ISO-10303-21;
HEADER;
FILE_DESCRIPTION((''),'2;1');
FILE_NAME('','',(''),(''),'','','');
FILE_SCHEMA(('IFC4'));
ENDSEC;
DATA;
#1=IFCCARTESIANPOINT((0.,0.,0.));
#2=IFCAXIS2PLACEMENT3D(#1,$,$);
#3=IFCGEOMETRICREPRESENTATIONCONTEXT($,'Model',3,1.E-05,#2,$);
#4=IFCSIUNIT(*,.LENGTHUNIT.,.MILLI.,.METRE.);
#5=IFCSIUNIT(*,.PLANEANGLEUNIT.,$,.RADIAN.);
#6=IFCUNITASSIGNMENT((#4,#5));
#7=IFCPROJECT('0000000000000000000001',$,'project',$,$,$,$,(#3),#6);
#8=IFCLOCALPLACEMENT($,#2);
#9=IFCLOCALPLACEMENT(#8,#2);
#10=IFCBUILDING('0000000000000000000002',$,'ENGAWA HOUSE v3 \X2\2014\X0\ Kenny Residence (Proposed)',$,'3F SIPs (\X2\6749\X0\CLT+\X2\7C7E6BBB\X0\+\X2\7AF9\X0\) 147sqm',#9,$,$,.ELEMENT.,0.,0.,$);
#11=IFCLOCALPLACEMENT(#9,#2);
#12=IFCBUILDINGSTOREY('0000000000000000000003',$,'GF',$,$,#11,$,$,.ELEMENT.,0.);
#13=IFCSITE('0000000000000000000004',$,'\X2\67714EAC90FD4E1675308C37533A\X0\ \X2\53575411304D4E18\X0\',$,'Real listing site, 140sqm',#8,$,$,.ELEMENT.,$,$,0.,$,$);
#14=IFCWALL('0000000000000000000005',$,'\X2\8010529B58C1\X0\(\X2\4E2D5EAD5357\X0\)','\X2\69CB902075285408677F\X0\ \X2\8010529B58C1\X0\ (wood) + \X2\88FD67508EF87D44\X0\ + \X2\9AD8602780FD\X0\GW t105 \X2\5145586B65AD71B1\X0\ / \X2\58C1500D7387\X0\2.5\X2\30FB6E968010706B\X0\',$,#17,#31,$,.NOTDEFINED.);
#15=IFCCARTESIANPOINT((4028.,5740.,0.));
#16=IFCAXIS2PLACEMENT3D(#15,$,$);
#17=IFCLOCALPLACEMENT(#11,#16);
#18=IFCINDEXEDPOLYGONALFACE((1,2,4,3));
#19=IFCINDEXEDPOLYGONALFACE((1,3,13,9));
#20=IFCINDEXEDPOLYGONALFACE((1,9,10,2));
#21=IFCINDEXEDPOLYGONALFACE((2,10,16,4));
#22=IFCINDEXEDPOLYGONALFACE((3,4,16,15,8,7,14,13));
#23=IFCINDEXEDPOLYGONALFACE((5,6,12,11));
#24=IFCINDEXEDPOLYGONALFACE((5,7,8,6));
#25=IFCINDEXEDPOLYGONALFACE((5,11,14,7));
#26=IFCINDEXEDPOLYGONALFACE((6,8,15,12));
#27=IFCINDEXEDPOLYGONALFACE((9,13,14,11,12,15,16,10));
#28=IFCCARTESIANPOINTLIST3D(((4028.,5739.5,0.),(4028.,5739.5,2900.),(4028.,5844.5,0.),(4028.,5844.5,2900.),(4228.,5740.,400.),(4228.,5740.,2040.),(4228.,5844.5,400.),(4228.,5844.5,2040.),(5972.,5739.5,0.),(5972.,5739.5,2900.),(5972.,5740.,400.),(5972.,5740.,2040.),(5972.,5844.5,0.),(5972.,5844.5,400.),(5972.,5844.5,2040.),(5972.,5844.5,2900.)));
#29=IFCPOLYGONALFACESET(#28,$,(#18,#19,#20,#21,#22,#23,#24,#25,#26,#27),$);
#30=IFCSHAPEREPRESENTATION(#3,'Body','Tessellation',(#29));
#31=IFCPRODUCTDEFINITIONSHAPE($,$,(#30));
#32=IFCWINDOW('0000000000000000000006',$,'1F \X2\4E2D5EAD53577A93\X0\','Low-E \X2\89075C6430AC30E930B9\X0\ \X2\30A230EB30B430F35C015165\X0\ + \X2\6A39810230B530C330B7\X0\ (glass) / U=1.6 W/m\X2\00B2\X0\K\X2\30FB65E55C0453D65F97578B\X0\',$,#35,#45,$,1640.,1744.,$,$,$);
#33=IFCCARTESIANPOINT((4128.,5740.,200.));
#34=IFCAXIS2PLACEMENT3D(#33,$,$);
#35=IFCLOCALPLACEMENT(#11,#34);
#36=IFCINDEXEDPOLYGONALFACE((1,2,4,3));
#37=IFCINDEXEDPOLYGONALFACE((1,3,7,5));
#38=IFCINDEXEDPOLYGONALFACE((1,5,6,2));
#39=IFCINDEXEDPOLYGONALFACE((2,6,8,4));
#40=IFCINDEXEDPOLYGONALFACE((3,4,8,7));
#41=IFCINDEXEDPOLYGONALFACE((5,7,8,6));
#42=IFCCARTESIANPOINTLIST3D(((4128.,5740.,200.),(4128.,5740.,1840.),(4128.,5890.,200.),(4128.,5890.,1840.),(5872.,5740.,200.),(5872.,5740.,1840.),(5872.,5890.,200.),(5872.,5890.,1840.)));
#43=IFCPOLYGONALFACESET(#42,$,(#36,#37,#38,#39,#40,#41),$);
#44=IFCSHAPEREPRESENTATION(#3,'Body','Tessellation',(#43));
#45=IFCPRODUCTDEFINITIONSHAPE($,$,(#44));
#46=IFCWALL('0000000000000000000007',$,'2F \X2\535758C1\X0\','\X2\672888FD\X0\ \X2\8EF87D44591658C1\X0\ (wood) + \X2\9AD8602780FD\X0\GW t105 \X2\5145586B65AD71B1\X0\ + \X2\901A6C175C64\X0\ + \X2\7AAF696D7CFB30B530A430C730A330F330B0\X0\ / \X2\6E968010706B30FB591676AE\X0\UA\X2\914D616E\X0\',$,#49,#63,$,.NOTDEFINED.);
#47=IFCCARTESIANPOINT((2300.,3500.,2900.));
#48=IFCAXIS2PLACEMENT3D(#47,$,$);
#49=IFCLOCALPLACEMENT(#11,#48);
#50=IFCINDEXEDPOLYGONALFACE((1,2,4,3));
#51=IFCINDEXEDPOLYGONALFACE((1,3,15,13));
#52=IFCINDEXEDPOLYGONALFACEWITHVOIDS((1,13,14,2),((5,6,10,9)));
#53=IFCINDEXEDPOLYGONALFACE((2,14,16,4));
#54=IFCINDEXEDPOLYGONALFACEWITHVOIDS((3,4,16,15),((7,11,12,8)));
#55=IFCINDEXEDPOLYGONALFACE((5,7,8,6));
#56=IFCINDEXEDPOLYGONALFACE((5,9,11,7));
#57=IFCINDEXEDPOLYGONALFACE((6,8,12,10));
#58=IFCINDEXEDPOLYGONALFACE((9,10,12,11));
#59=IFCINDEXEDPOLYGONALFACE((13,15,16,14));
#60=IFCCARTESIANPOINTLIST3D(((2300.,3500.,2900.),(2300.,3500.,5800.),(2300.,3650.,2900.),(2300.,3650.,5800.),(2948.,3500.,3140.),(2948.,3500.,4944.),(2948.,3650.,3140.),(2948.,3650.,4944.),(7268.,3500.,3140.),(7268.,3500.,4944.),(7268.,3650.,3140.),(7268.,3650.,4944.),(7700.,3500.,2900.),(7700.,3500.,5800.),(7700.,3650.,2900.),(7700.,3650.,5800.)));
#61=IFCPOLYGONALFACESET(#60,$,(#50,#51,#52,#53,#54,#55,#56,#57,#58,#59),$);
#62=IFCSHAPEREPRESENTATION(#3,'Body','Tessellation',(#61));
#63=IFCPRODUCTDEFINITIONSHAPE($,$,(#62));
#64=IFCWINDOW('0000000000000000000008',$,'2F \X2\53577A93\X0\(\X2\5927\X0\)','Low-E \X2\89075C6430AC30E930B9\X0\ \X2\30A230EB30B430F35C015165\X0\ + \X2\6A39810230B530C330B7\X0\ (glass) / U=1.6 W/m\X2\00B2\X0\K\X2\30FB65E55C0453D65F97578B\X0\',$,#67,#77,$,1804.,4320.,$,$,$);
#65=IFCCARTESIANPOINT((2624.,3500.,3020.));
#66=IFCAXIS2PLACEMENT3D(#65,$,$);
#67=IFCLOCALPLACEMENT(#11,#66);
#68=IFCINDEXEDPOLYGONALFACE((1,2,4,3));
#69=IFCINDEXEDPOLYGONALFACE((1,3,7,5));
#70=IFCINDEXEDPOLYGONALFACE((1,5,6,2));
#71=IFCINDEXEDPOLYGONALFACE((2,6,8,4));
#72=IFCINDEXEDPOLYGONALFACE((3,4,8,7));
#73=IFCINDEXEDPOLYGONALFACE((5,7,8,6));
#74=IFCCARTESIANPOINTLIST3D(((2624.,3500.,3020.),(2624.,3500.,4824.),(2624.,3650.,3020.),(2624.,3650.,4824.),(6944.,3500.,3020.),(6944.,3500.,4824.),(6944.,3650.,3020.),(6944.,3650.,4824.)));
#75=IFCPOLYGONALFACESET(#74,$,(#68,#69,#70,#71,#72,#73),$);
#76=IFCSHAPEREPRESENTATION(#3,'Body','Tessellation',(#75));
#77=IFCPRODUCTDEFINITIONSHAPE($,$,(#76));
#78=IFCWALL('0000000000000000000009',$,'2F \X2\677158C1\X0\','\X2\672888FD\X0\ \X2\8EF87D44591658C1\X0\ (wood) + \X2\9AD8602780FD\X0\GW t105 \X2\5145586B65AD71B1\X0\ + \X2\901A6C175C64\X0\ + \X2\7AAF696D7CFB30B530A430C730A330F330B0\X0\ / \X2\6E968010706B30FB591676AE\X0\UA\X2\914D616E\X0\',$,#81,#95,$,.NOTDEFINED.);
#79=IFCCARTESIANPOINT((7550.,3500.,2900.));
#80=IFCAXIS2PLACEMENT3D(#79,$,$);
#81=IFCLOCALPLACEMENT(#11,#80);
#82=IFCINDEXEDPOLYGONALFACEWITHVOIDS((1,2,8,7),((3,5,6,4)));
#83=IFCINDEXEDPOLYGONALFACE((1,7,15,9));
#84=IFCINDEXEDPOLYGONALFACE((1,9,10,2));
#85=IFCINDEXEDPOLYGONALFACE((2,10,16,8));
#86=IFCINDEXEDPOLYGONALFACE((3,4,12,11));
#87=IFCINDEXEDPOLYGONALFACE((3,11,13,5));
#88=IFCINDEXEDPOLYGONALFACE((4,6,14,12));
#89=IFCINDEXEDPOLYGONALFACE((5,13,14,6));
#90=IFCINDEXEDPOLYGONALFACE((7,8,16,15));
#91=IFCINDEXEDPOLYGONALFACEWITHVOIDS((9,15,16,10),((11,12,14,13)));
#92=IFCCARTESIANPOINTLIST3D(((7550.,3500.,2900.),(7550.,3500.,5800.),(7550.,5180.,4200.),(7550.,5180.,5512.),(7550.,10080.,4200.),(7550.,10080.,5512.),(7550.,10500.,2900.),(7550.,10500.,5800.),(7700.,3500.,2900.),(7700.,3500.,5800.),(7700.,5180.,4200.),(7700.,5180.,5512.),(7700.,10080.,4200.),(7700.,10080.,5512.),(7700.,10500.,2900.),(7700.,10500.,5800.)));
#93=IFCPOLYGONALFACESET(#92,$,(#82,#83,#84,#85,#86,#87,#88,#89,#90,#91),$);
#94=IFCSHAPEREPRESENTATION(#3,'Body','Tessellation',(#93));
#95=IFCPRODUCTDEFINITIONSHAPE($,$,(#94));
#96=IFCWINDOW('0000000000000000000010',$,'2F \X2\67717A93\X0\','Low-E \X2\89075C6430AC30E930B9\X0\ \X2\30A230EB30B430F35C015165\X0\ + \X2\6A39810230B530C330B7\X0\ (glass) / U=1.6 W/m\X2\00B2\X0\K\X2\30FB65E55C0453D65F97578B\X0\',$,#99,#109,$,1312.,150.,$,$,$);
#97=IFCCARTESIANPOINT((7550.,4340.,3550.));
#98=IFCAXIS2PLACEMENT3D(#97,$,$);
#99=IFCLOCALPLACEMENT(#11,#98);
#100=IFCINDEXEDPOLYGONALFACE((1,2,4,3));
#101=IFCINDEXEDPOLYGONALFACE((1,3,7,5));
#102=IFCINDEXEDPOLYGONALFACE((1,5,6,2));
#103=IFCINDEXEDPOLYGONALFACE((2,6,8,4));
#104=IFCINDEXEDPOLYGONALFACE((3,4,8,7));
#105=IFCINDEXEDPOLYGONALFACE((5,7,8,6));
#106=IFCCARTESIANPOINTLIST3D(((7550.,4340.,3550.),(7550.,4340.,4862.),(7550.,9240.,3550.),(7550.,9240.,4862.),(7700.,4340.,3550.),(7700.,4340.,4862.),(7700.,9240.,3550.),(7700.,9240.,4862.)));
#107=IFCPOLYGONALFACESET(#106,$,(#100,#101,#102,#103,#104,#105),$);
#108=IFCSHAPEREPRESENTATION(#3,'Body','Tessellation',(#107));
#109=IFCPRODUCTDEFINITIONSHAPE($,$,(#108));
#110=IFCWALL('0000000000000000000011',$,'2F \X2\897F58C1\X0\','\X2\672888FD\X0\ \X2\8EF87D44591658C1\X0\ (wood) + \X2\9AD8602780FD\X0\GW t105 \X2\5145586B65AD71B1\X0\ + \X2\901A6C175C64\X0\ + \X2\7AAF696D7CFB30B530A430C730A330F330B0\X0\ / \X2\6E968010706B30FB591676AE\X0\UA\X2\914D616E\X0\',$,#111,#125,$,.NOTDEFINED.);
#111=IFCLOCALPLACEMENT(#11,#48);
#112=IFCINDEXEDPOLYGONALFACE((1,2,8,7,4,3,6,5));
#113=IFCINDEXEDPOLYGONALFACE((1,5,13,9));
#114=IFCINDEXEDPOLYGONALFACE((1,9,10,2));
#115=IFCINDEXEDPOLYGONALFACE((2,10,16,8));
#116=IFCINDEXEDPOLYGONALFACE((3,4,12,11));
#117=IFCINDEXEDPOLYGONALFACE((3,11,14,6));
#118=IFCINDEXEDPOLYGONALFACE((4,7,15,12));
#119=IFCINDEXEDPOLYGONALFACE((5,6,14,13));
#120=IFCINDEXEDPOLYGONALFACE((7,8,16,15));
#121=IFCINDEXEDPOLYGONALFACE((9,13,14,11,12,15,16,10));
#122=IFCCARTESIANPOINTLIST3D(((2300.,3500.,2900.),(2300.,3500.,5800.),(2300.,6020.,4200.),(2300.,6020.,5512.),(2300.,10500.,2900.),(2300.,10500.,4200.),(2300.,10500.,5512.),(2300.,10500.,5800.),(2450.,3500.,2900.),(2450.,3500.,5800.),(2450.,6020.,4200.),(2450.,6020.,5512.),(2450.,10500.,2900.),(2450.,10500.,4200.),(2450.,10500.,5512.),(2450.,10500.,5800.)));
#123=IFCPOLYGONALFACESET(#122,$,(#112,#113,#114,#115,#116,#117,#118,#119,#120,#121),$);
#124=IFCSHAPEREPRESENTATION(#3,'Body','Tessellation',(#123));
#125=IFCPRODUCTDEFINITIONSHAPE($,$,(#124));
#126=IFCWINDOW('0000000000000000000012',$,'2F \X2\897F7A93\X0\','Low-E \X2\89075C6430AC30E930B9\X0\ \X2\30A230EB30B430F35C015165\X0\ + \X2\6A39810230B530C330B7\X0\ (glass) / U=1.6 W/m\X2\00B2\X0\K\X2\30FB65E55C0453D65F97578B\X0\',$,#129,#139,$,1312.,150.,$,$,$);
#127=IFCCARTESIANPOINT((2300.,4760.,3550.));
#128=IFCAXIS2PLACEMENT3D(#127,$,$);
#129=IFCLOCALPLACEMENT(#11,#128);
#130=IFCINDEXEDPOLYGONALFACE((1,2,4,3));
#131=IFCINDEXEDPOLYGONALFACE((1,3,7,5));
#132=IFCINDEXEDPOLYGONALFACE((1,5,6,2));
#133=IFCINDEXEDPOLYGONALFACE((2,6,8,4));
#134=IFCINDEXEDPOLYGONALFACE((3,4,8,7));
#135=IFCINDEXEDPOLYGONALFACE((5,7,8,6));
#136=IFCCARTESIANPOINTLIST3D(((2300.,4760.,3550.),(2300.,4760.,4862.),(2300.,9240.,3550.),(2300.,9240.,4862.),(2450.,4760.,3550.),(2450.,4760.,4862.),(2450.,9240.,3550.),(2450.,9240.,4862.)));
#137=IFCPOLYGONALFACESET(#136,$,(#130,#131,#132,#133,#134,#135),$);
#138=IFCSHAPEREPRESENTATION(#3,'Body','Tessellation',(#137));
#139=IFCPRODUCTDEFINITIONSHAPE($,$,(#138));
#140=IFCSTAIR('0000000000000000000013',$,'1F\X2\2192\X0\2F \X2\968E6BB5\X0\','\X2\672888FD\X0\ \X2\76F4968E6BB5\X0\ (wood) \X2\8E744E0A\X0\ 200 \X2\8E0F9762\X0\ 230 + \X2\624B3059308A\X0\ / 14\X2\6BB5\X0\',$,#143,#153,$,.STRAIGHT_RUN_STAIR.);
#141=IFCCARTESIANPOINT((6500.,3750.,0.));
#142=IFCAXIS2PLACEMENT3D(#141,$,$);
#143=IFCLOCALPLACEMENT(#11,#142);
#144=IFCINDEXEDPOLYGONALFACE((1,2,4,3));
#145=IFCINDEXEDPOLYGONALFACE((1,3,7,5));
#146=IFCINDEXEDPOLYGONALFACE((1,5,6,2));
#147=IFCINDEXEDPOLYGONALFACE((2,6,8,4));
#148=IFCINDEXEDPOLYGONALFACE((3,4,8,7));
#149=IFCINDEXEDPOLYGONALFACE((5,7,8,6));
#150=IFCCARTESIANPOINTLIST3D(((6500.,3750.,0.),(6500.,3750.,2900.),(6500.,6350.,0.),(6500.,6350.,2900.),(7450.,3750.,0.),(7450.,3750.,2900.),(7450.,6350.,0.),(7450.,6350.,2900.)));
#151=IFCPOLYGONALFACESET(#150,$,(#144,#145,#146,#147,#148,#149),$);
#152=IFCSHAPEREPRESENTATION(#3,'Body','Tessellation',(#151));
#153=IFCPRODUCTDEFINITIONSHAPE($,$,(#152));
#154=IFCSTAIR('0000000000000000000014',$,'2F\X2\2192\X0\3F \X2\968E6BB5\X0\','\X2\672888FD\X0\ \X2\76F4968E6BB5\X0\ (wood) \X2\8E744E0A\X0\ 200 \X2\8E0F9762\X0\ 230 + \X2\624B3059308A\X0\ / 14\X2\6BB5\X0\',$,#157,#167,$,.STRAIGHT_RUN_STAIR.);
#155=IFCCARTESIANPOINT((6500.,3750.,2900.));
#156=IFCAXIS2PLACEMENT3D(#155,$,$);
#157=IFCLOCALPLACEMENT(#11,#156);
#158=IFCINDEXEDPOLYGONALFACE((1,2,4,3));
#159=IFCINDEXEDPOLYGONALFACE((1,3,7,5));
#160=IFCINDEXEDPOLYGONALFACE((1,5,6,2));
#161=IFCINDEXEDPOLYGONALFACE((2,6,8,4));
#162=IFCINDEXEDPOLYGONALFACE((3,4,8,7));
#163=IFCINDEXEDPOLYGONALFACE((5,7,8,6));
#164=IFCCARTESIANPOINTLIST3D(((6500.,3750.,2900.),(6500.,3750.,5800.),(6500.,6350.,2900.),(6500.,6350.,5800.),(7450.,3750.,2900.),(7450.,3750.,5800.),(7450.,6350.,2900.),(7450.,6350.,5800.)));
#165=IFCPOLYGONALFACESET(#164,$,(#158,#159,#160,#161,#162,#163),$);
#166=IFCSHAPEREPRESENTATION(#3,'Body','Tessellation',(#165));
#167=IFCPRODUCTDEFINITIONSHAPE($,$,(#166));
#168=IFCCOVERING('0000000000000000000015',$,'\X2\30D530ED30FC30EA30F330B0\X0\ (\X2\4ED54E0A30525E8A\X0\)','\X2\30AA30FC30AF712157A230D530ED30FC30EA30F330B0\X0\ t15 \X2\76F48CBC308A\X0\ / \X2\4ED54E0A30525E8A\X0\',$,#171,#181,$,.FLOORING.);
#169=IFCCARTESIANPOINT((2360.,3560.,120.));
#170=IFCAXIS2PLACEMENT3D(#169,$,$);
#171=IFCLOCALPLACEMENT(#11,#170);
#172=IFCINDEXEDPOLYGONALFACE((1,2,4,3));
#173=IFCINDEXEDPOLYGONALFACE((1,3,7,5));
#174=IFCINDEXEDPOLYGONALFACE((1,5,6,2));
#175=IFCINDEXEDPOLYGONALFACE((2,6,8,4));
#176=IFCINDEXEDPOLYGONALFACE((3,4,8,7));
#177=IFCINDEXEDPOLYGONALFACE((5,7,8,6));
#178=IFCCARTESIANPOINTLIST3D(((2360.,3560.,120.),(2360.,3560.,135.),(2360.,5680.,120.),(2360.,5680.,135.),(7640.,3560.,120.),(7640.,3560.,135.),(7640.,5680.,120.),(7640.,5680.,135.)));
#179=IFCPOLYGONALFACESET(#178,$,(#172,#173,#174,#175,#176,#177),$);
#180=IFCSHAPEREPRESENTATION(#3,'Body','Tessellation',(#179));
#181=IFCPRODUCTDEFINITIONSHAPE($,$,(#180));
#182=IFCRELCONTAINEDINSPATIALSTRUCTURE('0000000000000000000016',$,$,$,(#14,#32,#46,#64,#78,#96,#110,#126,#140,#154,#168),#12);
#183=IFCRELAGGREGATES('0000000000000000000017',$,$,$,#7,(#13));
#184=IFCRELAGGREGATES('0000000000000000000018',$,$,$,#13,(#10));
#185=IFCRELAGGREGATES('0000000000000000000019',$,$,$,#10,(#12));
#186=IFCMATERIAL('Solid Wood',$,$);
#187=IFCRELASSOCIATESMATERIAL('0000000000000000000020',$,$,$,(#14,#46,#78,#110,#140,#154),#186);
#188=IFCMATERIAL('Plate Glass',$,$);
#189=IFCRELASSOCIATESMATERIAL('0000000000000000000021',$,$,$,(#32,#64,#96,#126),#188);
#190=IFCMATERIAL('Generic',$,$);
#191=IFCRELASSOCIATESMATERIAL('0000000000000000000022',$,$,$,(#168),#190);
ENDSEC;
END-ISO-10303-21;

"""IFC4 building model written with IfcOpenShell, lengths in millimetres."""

from ifc_helpers import new_model, si_unit, frame, frame_2d, origin, place, context, project, spatial, rectangle, extrude, material, element, fill, save


model = new_model("IFC4")

# Units and contexts
model_context = context("Model", 3, precision=1e-05, world=origin())
ifc_project = project(units=[si_unit("LENGTHUNIT", "METRE", prefix="MILLI"), si_unit("PLANEANGLEUNIT", "RADIAN")], contexts=[model_context])

# Site, building, storey
site_placement = place(None, origin())
site = spatial("IfcSite", under=ifc_project, at=site_placement, Name="東京都世田谷区 南向き丘", ObjectType="Real listing site, 140sqm", CompositionType="ELEMENT", RefElevation=0.0)
building_placement = place(site_placement, origin())
building = spatial("IfcBuilding", under=site, at=building_placement, Name="ENGAWA HOUSE v3 — Kenny Residence (Proposed)", ObjectType="3F SIPs (杉CLT+籾殻+竹) 147sqm", CompositionType="ELEMENT", ElevationOfRefHeight=0.0, ElevationOfTerrain=0.0)
storey_placement = place(building_placement, origin())
storey = spatial("IfcBuildingStorey", under=building, at=storey_placement, Name="GF", CompositionType="ELEMENT", Elevation=0.0)

# Shared definitions
ifc_material_1 = material(Name="Solid Wood")
ifc_material_2 = material(Name="Generic")

# Shared definitions
ifc_material_3 = material(Name="Plate Glass")

# Walls, openings, windows
wall_1_placement = place(storey_placement, frame((4028.0, 5740.0, 0.0)))
wall_1 = element("IfcWall", 1, at=wall_1_placement, inside=storey, material=ifc_material_1, Name="耐力壁(中庭南)", Description="構造用合板 耐力壁 (wood) + 製材軸組 + 高性能GW t105 充填断熱 / 壁倍率2.5・準耐火", PredefinedType="NOTDEFINED", context=model_context, shape_type="SweptSolid", body=[
    extrude(rectangle(XDim=1944.0, YDim=105.0, at=frame_2d((972.0, 52.0))), frame((4028.0, 5740.0, 0.0)), (0.0, 0.0, 1.0), 2900.0),
])
opening_1_placement = place(storey_placement, frame((4128.0, 5740.0, 200.0)))
opening_1 = element("IfcOpeningElement", 2, at=opening_1_placement, cuts=wall_1, PredefinedType="NOTDEFINED", context=model_context, shape_type="SweptSolid", body=[
    extrude(rectangle(XDim=1744.0, YDim=150.0, at=frame_2d((872.0, 75.0))), frame((4128.0, 5740.0, 200.0)), (0.0, 0.0, 1.0), 1640.0),
])
window_1_placement = place(storey_placement, frame((4128.0, 5740.0, 200.0)))
window_1 = element("IfcWindow", 3, at=window_1_placement, inside=storey, material=ifc_material_3, Name="1F 中庭南窓", Description="Low-E 複層ガラス アルゴン封入 + 樹脂サッシ (glass) / U=1.6 W/m²K・日射取得型", OverallHeight=1640.0, OverallWidth=1744.0, context=model_context, shape_type="SweptSolid", body=[
    extrude(rectangle(XDim=1744.0, YDim=150.0, at=frame_2d((872.0, 75.0))), frame((4128.0, 5740.0, 200.0)), (0.0, 0.0, 1.0), 1640.0),
])
fill(opening_1, window_1)
wall_2_placement = place(storey_placement, frame((2300.0, 3500.0, 2900.0)))
wall_2 = element("IfcWall", 4, at=wall_2_placement, inside=storey, material=ifc_material_1, Name="2F 南壁", Description="木製 軸組外壁 (wood) + 高性能GW t105 充填断熱 + 通気層 + 窯業系サイディング / 準耐火・外皮UA配慮", PredefinedType="NOTDEFINED", context=model_context, shape_type="SweptSolid", body=[
    extrude(rectangle(XDim=5400.0, YDim=150.0, at=frame_2d((2700.0, 75.0))), frame((2300.0, 3500.0, 2900.0)), (0.0, 0.0, 1.0), 2900.0),
])
opening_2_placement = place(storey_placement, frame((2624.0, 3500.0, 3020.0)))
opening_2 = element("IfcOpeningElement", 5, at=opening_2_placement, cuts=wall_2, PredefinedType="NOTDEFINED", context=model_context, shape_type="SweptSolid", body=[
    extrude(rectangle(XDim=4320.0, YDim=150.0, at=frame_2d((2160.0, 75.0))), frame((2624.0, 3500.0, 3020.0)), (0.0, 0.0, 1.0), 1804.0),
])
window_2_placement = place(storey_placement, frame((2624.0, 3500.0, 3020.0)))
window_2 = element("IfcWindow", 6, at=window_2_placement, inside=storey, material=ifc_material_3, Name="2F 南窓(大)", Description="Low-E 複層ガラス アルゴン封入 + 樹脂サッシ (glass) / U=1.6 W/m²K・日射取得型", OverallHeight=1804.0, OverallWidth=4320.0, context=model_context, shape_type="SweptSolid", body=[
    extrude(rectangle(XDim=4320.0, YDim=150.0, at=frame_2d((2160.0, 75.0))), frame((2624.0, 3500.0, 3020.0)), (0.0, 0.0, 1.0), 1804.0),
])
fill(opening_2, window_2)
wall_3_placement = place(storey_placement, frame((7550.0, 3500.0, 2900.0)))
wall_3 = element("IfcWall", 7, at=wall_3_placement, inside=storey, material=ifc_material_1, Name="2F 東壁", Description="木製 軸組外壁 (wood) + 高性能GW t105 充填断熱 + 通気層 + 窯業系サイディング / 準耐火・外皮UA配慮", PredefinedType="NOTDEFINED", context=model_context, shape_type="SweptSolid", body=[
    extrude(rectangle(XDim=150.0, YDim=7000.0, at=frame_2d((75.0, 3500.0))), frame((7550.0, 3500.0, 2900.0)), (0.0, 0.0, 1.0), 2900.0),
])
opening_3_placement = place(storey_placement, frame((7550.0, 4340.0, 3550.0)))
opening_3 = element("IfcOpeningElement", 8, at=opening_3_placement, cuts=wall_3, PredefinedType="NOTDEFINED", context=model_context, shape_type="SweptSolid", body=[
    extrude(rectangle(XDim=150.0, YDim=4900.0, at=frame_2d((75.0, 2450.0))), frame((7550.0, 4340.0, 3550.0)), (0.0, 0.0, 1.0), 1312.0),
])
window_3_placement = place(storey_placement, frame((7550.0, 4340.0, 3550.0)))
window_3 = element("IfcWindow", 9, at=window_3_placement, inside=storey, material=ifc_material_3, Name="2F 東窓", Description="Low-E 複層ガラス アルゴン封入 + 樹脂サッシ (glass) / U=1.6 W/m²K・日射取得型", OverallHeight=1312.0, OverallWidth=150.0, context=model_context, shape_type="SweptSolid", body=[
    extrude(rectangle(XDim=150.0, YDim=4900.0, at=frame_2d((75.0, 2450.0))), frame((7550.0, 4340.0, 3550.0)), (0.0, 0.0, 1.0), 1312.0),
])
fill(opening_3, window_3)
wall_4_placement = place(storey_placement, frame((2300.0, 3500.0, 2900.0)))
wall_4 = element("IfcWall", 10, at=wall_4_placement, inside=storey, material=ifc_material_1, Name="2F 西壁", Description="木製 軸組外壁 (wood) + 高性能GW t105 充填断熱 + 通気層 + 窯業系サイディング / 準耐火・外皮UA配慮", PredefinedType="NOTDEFINED", context=model_context, shape_type="SweptSolid", body=[
    extrude(rectangle(XDim=150.0, YDim=7000.0, at=frame_2d((75.0, 3500.0))), frame((2300.0, 3500.0, 2900.0)), (0.0, 0.0, 1.0), 2900.0),
])
opening_4_placement = place(storey_placement, frame((2300.0, 4760.0, 3550.0)))
opening_4 = element("IfcOpeningElement", 11, at=opening_4_placement, cuts=wall_4, PredefinedType="NOTDEFINED", context=model_context, shape_type="SweptSolid", body=[
    extrude(rectangle(XDim=150.0, YDim=4480.0, at=frame_2d((75.0, 2240.0))), frame((2300.0, 4760.0, 3550.0)), (0.0, 0.0, 1.0), 1312.0),
])
window_4_placement = place(storey_placement, frame((2300.0, 4760.0, 3550.0)))
window_4 = element("IfcWindow", 12, at=window_4_placement, inside=storey, material=ifc_material_3, Name="2F 西窓", Description="Low-E 複層ガラス アルゴン封入 + 樹脂サッシ (glass) / U=1.6 W/m²K・日射取得型", OverallHeight=1312.0, OverallWidth=150.0, context=model_context, shape_type="SweptSolid", body=[
    extrude(rectangle(XDim=150.0, YDim=4480.0, at=frame_2d((75.0, 2240.0))), frame((2300.0, 4760.0, 3550.0)), (0.0, 0.0, 1.0), 1312.0),
])
fill(opening_4, window_4)

# Stairs
stair_1_placement = place(storey_placement, frame((6500.0, 3750.0, 0.0)))
element("IfcStair", 13, at=stair_1_placement, inside=storey, material=ifc_material_1, Name="1F→2F 階段", Description="木製 直階段 (wood) 蹴上 200 踏面 230 + 手すり / 14段", PredefinedType="STRAIGHT_RUN_STAIR", context=model_context, shape_type="SweptSolid", body=[
    extrude(rectangle(XDim=950.0, YDim=2600.0, at=frame_2d((475.0, 1300.0))), frame((6500.0, 3750.0, 0.0)), (0.0, 0.0, 1.0), 2900.0),
])
stair_2_placement = place(storey_placement, frame((6500.0, 3750.0, 2900.0)))
element("IfcStair", 14, at=stair_2_placement, inside=storey, material=ifc_material_1, Name="2F→3F 階段", Description="木製 直階段 (wood) 蹴上 200 踏面 230 + 手すり / 14段", PredefinedType="STRAIGHT_RUN_STAIR", context=model_context, shape_type="SweptSolid", body=[
    extrude(rectangle(XDim=950.0, YDim=2600.0, at=frame_2d((475.0, 1300.0))), frame((6500.0, 3750.0, 2900.0)), (0.0, 0.0, 1.0), 2900.0),
])

# Covering
covering_placement = place(storey_placement, frame((2360.0, 3560.0, 120.0)))
element("IfcCovering", 15, at=covering_placement, inside=storey, material=ifc_material_2, Name="フローリング (仕上げ床)", Description="オーク無垢フローリング t15 直貼り / 仕上げ床", PredefinedType="FLOORING", context=model_context, shape_type="SweptSolid", body=[
    extrude(rectangle(XDim=5280.0, YDim=2120.0, at=frame_2d((2640.0, 1060.0))), frame((2360.0, 3560.0, 120.0)), (0.0, 0.0, 1.0), 15.0),
])

save(model, "model.ifc")
